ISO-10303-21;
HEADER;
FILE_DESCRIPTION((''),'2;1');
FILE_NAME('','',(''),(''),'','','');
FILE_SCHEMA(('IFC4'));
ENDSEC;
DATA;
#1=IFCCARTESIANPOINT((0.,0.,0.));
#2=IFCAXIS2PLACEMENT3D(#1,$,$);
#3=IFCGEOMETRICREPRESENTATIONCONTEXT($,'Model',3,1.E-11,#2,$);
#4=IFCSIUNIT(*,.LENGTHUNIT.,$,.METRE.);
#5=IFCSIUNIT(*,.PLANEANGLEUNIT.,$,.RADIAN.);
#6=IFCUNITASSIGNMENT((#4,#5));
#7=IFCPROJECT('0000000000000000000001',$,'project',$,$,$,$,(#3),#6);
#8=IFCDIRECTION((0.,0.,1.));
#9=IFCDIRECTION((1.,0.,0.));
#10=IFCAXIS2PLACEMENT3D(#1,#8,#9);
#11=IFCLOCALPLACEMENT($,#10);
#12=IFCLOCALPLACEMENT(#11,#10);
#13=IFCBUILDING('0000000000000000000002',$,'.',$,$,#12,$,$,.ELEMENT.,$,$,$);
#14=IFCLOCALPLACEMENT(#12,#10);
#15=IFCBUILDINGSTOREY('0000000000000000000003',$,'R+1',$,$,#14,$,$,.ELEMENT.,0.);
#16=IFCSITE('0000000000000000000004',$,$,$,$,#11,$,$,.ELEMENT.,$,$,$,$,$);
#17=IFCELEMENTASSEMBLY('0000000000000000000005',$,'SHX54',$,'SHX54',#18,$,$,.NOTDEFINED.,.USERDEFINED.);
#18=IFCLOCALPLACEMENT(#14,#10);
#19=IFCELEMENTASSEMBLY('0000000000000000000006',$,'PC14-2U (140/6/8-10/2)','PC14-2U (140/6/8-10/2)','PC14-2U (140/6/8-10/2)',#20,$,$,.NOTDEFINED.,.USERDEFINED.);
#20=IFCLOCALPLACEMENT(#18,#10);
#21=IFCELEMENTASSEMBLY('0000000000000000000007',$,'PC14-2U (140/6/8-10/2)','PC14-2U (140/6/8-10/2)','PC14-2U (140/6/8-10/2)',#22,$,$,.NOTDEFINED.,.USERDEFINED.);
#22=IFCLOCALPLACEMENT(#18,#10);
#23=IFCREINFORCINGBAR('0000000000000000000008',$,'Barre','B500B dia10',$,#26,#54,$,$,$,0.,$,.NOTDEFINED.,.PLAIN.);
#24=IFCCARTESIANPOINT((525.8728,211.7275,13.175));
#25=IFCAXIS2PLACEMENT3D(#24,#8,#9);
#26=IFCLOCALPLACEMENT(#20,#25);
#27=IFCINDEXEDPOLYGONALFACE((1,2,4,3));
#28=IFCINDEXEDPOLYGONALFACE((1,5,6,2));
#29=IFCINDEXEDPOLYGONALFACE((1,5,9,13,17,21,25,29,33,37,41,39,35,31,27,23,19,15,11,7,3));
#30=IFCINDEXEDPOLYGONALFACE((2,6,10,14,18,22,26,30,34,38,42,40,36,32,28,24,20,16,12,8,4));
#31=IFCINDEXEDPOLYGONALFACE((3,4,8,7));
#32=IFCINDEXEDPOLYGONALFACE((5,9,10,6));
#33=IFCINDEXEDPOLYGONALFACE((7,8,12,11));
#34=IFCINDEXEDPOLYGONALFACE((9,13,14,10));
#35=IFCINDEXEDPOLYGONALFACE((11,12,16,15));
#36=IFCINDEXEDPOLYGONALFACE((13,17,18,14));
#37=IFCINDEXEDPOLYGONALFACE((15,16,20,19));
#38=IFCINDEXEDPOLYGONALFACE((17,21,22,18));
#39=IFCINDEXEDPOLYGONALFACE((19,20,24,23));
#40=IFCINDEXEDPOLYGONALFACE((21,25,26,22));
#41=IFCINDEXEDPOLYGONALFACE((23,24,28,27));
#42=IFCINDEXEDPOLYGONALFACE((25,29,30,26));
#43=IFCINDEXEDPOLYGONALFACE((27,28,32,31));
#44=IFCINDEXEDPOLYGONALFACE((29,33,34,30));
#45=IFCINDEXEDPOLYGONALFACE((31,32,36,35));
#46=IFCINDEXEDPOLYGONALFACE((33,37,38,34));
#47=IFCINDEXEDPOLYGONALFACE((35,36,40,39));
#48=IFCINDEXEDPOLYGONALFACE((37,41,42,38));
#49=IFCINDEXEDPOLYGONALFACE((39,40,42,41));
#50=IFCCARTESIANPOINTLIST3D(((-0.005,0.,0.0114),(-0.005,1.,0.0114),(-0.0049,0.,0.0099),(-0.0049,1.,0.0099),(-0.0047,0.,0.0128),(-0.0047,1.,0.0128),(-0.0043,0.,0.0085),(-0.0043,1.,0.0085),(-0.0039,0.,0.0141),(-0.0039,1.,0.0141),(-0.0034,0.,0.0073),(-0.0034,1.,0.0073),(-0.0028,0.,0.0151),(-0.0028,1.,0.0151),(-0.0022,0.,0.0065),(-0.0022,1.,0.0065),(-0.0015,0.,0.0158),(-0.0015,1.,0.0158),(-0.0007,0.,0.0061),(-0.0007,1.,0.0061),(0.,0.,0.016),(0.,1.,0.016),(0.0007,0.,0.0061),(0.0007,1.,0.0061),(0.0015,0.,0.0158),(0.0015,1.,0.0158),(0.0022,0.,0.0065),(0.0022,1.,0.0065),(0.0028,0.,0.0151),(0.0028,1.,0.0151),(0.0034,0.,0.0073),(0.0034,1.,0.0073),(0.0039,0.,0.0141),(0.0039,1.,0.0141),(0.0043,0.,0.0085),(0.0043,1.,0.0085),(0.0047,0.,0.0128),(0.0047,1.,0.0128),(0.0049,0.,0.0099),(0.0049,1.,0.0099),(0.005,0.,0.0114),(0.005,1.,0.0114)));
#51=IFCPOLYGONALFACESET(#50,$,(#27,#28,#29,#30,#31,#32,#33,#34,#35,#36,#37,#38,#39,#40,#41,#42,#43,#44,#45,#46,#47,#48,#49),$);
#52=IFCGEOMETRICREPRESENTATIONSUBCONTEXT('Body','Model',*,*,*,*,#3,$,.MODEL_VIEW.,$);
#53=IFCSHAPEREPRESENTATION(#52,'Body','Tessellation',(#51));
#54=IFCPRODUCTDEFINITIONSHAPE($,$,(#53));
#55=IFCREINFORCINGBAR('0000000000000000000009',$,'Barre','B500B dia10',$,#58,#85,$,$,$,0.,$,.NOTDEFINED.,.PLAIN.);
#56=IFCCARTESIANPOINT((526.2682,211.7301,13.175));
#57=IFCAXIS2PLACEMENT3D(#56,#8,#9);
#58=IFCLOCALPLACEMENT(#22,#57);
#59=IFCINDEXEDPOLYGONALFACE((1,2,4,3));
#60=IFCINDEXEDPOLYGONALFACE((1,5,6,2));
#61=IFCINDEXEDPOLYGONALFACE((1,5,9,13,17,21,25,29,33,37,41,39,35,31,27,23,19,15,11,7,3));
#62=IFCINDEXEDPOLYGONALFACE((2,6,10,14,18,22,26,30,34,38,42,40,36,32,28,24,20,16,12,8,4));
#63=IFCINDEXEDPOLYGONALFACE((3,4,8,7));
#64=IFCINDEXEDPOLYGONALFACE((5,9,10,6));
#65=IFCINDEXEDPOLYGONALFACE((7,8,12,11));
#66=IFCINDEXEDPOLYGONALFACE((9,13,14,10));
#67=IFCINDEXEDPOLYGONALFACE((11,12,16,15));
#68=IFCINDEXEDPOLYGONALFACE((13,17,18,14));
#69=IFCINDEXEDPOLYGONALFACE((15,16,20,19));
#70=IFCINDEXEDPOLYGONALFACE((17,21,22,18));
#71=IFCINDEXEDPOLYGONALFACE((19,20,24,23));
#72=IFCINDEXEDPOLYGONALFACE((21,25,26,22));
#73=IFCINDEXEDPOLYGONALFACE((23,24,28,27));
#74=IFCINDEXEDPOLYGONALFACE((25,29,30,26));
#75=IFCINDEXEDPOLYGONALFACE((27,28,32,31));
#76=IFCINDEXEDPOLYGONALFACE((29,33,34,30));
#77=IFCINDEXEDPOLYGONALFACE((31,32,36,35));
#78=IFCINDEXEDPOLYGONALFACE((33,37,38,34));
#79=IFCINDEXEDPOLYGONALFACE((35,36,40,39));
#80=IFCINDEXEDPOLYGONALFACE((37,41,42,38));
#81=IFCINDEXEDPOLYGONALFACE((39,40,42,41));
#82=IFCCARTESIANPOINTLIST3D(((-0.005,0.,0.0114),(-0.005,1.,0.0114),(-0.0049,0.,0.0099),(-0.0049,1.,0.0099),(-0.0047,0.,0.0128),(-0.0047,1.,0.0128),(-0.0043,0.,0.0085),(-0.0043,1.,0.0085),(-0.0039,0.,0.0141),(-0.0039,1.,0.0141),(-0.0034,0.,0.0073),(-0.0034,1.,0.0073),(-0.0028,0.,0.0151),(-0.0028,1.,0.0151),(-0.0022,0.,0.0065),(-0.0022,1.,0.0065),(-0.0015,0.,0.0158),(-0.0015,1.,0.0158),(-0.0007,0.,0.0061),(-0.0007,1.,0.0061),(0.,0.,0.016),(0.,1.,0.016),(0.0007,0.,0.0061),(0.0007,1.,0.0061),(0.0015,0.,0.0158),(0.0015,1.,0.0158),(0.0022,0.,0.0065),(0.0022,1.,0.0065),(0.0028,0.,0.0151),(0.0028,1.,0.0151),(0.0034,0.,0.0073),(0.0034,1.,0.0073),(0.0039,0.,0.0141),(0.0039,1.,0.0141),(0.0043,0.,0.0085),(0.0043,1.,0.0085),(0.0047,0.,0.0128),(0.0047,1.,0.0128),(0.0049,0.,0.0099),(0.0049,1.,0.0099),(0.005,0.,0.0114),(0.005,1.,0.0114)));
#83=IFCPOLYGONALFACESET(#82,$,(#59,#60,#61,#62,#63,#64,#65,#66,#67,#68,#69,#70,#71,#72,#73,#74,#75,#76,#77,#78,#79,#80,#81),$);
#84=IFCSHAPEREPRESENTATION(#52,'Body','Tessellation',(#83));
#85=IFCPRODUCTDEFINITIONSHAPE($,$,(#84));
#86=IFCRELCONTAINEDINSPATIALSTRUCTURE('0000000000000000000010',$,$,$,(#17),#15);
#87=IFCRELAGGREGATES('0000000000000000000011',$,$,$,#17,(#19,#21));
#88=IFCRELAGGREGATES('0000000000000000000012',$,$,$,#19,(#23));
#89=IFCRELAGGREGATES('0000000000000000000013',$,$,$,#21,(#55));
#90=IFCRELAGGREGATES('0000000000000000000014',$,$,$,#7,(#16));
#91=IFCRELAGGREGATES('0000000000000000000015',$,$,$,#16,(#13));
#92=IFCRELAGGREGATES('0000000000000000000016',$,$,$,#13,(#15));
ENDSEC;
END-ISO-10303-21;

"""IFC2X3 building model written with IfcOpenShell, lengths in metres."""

from ifc_helpers import new_model, entity, si_unit, frame, origin, origin_with_axes, place, context, subcontext, project, spatial, source, transform, mapped, element, aggregate, save


model = new_model("IFC2X3")

# Units and contexts
model_context = context("Model", 3, precision=1e-11, world=origin())
body_context = subcontext(model_context, "Body", "Model", "MODEL_VIEW")
ifc_project = project(units=[si_unit("LENGTHUNIT", "METRE"), si_unit("PLANEANGLEUNIT", "RADIAN")], contexts=[model_context])

# Site, building, storey
site_placement = place(None, origin_with_axes())
site = spatial("IfcSite", under=ifc_project, at=site_placement, CompositionType="ELEMENT")
building_placement = place(site_placement, origin_with_axes())
building = spatial("IfcBuilding", under=site, at=building_placement, Name=".", CompositionType="ELEMENT")
storey_placement = place(building_placement, origin_with_axes())
storey = spatial("IfcBuildingStorey", under=building, at=storey_placement, Name="R+1", CompositionType="ELEMENT", Elevation=0.0)

# Element assemblies, reinforcing bars
assembly_1_placement = place(storey_placement, origin_with_axes())
assembly_1 = element("IfcElementAssembly", 1, at=assembly_1_placement, inside=storey, Name="SHX54", ObjectType="SHX54", AssemblyPlace="NOTDEFINED", PredefinedType="USERDEFINED")
assembly_2_placement = place(assembly_1_placement, origin_with_axes())
assembly_2 = element("IfcElementAssembly", 2, at=assembly_2_placement, Name="PC14-2U (140/6/8-10/2)", Description="PC14-2U (140/6/8-10/2)", ObjectType="PC14-2U (140/6/8-10/2)", AssemblyPlace="NOTDEFINED", PredefinedType="USERDEFINED")
assembly_3_placement = place(assembly_1_placement, origin_with_axes())
assembly_3 = element("IfcElementAssembly", 3, at=assembly_3_placement, Name="PC14-2U (140/6/8-10/2)", Description="PC14-2U (140/6/8-10/2)", ObjectType="PC14-2U (140/6/8-10/2)", AssemblyPlace="NOTDEFINED", PredefinedType="USERDEFINED")
aggregate(assembly_1, [assembly_2, assembly_3])
shared_shape_1 = source(origin_with_axes(), body_context, "Body", "AdvancedSweptSolid", [
    entity("IfcSweptDiskSolid", entity("IfcPolyline", [entity("IfcCartesianPoint", [0.0, 0.0, 0.011]), entity("IfcCartesianPoint", [0.0, 1.0, 0.011])]), 0.005, None, 0.0, 1.0),
])
reinforcing_bar_1_placement = place(assembly_2_placement, frame((525.8728, 211.7275, 13.175), z_axis=(0.0, 0.0, 1.0), x_axis=(1.0, 0.0, 0.0)))
reinforcing_bar_1 = element("IfcReinforcingBar", 4, at=reinforcing_bar_1_placement, Name="Barre", Description="B500B dia10", BarRole="NOTDEFINED", BarSurface="PLAIN", CrossSectionArea=0.0, context=body_context, shape_type="MappedRepresentation", body=[
    mapped(shared_shape_1, transform((0.0, 0.0, 0.0), scale=1.0)),
])
aggregate(assembly_2, [reinforcing_bar_1])
reinforcing_bar_2_placement = place(assembly_3_placement, frame((526.2682, 211.7301, 13.175), z_axis=(0.0, 0.0, 1.0), x_axis=(1.0, 0.0, 0.0)))
reinforcing_bar_2 = element("IfcReinforcingBar", 5, at=reinforcing_bar_2_placement, Name="Barre", Description="B500B dia10", BarRole="NOTDEFINED", BarSurface="PLAIN", CrossSectionArea=0.0, context=body_context, shape_type="MappedRepresentation", body=[
    mapped(shared_shape_1, transform((0.0, 0.0, 0.0), scale=1.0)),
])
aggregate(assembly_3, [reinforcing_bar_2])

save(model, "model.ifc")
